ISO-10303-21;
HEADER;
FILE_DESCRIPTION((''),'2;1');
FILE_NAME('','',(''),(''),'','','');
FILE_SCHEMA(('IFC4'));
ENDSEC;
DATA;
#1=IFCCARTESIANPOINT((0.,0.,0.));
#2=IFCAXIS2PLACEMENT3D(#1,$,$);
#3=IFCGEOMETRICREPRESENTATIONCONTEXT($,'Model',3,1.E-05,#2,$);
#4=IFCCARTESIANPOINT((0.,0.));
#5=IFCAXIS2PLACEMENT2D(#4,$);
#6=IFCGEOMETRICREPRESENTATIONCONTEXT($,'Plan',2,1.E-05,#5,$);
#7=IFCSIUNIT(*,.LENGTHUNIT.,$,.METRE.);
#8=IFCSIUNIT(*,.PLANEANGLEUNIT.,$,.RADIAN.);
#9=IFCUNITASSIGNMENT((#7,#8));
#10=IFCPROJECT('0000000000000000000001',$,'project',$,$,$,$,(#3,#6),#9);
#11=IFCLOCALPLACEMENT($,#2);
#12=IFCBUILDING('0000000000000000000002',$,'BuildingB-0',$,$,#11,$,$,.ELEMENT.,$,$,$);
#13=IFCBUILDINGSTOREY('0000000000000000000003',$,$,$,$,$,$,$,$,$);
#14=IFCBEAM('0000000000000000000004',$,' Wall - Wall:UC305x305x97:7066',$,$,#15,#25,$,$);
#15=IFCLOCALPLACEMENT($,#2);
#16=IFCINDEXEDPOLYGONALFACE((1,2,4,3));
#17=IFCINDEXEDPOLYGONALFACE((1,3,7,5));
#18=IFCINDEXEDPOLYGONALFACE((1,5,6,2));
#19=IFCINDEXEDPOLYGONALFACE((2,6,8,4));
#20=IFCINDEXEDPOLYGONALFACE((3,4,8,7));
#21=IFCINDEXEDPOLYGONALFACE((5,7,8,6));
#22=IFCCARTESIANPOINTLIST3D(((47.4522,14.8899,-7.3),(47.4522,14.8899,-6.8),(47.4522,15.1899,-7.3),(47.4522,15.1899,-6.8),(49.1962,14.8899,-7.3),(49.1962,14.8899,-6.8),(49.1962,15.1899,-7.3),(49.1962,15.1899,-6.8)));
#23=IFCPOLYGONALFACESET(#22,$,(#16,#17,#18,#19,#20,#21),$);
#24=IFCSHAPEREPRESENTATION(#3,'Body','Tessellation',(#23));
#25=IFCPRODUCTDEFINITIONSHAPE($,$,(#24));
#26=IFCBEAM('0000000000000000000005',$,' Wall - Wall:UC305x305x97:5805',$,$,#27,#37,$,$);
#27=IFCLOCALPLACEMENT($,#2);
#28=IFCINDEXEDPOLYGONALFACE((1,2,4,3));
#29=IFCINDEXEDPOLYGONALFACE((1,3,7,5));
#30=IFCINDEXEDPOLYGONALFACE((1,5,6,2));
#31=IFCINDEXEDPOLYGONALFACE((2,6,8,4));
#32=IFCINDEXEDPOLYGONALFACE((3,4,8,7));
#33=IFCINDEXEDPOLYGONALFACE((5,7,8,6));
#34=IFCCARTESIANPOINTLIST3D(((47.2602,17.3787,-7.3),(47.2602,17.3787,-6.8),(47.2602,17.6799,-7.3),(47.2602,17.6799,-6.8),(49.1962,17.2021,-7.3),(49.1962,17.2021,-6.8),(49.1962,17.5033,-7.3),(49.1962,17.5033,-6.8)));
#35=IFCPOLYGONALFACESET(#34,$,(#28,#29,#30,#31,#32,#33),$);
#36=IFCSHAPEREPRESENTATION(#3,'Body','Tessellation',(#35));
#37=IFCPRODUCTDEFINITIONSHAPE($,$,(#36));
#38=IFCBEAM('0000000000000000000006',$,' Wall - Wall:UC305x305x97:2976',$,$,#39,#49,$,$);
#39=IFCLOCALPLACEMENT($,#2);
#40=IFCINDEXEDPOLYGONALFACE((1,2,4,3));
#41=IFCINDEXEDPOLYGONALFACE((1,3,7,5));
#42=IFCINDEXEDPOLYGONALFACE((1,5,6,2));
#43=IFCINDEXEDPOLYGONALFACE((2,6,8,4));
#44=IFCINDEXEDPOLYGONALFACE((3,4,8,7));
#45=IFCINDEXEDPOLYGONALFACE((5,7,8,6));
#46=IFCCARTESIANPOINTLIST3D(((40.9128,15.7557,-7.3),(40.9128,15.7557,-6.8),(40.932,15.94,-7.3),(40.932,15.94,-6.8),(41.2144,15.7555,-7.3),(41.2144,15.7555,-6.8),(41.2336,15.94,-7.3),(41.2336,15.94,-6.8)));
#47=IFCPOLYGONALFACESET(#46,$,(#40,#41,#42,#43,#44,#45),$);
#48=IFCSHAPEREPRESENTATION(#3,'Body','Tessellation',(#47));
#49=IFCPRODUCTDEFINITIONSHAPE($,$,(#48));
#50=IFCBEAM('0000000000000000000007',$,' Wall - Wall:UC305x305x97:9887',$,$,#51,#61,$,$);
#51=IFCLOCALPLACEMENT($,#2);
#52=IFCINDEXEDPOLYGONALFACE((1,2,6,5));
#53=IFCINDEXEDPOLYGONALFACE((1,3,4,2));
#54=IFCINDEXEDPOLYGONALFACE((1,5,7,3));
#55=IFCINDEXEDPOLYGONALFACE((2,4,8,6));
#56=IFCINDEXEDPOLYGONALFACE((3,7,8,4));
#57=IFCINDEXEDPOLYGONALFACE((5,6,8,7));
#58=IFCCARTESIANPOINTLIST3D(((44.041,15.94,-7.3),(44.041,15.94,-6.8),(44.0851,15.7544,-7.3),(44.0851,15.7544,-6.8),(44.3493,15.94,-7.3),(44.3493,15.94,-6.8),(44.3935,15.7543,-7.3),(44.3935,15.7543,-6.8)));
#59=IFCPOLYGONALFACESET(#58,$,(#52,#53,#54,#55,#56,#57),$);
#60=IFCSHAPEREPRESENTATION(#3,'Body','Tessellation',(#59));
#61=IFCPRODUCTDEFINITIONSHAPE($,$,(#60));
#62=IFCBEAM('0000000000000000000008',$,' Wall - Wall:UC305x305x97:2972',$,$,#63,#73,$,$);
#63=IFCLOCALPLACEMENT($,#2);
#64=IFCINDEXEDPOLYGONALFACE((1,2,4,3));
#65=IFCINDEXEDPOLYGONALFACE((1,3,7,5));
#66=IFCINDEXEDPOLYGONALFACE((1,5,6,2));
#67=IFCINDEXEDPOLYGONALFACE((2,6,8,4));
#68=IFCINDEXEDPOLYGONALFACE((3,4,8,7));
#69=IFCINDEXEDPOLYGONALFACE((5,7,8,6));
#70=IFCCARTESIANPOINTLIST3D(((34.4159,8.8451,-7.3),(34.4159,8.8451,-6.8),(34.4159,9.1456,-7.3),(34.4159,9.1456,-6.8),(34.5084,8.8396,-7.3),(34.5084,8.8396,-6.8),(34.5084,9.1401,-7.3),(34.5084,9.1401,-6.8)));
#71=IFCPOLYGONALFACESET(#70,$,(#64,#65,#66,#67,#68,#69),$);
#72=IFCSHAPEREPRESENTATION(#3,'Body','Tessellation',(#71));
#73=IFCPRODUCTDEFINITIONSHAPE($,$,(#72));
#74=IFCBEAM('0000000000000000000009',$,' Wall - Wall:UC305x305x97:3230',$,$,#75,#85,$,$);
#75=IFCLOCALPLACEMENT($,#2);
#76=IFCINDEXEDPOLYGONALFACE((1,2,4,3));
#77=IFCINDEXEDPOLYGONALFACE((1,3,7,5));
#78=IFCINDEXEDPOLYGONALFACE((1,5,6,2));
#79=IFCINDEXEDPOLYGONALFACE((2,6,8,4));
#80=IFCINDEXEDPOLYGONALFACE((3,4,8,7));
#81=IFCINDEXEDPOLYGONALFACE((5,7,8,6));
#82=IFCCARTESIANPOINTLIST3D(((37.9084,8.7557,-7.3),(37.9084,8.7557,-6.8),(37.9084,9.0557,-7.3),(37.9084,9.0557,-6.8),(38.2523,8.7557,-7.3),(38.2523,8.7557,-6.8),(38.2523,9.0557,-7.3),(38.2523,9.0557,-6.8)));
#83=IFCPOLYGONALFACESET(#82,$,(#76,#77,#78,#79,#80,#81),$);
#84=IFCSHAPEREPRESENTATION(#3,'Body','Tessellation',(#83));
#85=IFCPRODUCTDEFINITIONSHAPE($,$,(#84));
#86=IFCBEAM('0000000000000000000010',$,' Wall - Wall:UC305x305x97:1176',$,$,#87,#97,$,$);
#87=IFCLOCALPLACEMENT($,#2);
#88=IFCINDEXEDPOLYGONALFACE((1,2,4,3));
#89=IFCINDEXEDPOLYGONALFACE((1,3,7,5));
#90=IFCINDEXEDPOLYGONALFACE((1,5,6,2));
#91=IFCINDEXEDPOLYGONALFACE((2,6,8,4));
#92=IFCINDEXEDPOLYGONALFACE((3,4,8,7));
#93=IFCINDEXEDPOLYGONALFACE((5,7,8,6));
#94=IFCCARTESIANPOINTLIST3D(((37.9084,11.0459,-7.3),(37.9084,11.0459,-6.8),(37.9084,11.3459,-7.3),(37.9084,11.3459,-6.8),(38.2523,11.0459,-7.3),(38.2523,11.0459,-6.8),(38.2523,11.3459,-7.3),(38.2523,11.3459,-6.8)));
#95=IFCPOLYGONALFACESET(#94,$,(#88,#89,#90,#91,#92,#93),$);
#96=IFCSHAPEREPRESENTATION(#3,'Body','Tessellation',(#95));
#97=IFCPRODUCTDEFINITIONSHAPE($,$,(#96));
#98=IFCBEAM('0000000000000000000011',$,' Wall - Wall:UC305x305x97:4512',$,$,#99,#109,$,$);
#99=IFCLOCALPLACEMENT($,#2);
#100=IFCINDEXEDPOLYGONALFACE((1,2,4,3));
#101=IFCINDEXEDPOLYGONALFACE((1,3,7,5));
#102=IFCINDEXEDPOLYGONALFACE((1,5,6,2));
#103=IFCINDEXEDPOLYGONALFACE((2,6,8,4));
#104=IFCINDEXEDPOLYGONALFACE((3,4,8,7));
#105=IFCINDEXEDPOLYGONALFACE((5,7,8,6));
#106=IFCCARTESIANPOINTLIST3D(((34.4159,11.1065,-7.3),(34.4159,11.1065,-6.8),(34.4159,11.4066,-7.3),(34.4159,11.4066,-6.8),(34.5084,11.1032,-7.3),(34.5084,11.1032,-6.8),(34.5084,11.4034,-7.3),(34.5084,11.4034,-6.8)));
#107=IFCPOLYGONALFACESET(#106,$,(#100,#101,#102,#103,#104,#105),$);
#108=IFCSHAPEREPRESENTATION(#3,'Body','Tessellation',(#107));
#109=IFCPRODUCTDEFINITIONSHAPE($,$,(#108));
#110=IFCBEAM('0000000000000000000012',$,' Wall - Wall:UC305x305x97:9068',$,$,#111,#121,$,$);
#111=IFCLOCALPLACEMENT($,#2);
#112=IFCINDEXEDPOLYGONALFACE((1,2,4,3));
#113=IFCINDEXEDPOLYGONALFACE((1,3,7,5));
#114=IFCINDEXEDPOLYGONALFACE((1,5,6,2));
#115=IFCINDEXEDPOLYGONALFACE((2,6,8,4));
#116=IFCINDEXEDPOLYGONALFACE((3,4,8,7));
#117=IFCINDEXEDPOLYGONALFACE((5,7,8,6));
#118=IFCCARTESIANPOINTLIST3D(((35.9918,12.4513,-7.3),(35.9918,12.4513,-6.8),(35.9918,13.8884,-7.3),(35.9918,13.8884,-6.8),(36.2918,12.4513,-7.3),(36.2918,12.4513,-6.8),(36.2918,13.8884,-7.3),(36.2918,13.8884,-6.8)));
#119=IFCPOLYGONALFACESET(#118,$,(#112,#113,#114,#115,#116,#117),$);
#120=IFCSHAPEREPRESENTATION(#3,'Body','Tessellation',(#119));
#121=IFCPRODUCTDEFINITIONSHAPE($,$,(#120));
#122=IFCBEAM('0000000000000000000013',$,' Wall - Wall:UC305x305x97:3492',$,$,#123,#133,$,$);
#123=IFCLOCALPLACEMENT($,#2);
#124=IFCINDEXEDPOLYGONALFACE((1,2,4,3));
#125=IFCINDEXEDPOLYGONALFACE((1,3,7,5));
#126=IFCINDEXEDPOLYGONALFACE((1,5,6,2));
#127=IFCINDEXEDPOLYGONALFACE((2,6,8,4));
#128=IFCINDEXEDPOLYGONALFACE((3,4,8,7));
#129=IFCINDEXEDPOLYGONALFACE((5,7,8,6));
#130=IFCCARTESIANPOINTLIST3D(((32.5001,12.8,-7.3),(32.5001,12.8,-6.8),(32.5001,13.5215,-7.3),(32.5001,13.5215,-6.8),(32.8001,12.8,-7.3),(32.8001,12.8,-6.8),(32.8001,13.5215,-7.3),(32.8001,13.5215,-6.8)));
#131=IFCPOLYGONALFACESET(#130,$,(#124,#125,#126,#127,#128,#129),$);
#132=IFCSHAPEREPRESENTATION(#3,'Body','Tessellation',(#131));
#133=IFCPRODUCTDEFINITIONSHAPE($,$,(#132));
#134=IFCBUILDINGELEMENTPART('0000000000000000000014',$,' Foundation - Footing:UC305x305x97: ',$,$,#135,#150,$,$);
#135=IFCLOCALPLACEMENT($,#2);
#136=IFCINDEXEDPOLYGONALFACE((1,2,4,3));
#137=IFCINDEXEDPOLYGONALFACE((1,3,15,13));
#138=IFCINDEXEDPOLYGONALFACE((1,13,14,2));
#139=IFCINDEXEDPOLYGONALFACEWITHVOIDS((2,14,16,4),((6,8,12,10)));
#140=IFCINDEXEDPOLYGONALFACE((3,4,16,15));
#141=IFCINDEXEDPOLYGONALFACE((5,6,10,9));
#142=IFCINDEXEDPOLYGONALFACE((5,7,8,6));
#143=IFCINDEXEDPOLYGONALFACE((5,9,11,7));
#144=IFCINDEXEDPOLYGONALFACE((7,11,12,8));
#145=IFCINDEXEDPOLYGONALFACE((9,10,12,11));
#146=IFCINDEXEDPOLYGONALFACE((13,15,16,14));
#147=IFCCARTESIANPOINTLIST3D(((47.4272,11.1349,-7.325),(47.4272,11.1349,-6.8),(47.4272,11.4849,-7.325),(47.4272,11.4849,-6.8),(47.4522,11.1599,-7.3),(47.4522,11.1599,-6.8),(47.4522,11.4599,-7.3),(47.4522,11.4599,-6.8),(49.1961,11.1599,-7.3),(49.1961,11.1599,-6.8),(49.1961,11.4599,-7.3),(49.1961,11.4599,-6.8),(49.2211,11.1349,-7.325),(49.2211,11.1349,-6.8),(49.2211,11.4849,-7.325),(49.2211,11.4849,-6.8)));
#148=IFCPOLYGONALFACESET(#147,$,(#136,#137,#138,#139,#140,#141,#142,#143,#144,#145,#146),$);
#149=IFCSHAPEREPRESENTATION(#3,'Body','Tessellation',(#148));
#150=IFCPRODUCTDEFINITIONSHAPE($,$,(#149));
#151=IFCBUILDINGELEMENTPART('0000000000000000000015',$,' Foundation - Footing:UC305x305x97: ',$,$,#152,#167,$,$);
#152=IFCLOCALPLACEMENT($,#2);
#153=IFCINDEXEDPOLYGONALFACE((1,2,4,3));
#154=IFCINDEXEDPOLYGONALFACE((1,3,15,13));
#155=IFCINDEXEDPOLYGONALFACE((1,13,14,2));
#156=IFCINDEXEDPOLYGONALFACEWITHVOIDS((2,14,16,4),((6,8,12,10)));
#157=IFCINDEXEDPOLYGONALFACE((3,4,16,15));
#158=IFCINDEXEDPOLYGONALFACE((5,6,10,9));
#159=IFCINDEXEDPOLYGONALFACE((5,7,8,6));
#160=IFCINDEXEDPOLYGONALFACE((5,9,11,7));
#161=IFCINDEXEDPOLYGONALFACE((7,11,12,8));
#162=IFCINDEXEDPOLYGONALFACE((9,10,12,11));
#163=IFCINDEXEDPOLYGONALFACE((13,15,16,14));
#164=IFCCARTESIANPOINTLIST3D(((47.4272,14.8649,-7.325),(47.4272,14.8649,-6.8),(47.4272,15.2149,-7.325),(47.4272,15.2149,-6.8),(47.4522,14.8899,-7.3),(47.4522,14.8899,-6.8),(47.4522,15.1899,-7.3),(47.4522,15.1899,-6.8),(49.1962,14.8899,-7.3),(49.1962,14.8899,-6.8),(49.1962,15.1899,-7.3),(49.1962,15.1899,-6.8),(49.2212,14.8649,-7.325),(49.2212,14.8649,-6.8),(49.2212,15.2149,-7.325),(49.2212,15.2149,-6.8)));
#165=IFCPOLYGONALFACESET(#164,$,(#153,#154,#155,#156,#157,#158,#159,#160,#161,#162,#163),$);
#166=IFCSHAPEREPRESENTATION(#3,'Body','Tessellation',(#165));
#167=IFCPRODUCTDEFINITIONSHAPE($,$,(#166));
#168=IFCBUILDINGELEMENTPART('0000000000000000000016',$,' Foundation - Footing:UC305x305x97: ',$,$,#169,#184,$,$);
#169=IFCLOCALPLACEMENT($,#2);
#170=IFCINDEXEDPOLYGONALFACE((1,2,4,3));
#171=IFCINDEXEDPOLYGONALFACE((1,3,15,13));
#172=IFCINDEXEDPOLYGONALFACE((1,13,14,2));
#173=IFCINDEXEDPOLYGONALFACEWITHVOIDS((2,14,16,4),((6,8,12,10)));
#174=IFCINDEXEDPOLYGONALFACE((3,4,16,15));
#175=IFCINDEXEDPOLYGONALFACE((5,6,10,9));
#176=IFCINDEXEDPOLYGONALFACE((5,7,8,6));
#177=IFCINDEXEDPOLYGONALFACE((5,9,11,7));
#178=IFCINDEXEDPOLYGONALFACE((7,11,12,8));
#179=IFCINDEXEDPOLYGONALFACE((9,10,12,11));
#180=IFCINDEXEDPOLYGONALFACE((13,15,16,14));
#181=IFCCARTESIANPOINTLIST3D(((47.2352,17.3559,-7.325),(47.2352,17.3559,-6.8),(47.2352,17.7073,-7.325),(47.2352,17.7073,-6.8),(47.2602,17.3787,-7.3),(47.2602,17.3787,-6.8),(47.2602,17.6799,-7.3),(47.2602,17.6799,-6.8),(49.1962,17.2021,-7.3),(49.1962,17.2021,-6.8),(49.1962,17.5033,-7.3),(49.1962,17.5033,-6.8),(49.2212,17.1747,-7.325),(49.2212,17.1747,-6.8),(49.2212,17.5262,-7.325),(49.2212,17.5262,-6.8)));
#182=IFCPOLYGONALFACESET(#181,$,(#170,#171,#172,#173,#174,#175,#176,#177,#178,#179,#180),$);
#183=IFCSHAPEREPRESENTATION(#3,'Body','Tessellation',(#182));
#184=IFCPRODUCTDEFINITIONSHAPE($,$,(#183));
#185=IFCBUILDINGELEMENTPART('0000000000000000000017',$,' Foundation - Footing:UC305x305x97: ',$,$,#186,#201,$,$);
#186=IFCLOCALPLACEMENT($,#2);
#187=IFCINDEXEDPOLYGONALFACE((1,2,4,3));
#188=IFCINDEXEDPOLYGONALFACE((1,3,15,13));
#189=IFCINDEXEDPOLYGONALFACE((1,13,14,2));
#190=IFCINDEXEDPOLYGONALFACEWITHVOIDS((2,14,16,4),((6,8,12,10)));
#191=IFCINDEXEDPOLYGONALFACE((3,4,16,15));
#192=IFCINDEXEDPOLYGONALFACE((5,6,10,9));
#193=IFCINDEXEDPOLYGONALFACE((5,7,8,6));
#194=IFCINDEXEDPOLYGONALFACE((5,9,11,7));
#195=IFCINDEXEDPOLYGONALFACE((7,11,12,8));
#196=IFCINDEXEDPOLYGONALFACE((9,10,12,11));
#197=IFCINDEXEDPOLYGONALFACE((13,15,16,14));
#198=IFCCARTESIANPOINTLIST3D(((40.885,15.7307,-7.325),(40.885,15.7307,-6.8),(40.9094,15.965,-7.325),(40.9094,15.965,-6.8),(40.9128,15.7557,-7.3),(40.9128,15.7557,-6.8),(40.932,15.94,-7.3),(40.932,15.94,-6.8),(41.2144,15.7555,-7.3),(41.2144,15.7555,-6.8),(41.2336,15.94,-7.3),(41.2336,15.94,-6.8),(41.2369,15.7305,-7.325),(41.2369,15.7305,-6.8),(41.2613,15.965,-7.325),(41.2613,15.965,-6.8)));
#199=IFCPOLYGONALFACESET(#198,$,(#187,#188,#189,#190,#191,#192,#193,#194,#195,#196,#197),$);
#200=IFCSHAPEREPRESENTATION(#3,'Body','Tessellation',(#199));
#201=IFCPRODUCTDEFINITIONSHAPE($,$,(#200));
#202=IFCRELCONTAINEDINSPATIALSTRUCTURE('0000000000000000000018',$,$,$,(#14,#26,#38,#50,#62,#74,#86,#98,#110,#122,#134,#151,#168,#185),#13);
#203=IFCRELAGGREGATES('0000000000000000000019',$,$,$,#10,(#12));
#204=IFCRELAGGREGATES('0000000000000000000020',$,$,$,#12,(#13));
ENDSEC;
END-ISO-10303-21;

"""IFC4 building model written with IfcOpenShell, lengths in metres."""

from ifc_helpers import new_model, si_unit, origin, origin_2d, place, context, project, spatial, polyline, outline, extrude, element, save


model = new_model("IFC4")

# Units and contexts
model_context = context("Model", 3, precision=1e-05, world=origin())
plan_context = context("Plan", 2, precision=1e-05, world=origin_2d())
ifc_project = project(units=[si_unit("LENGTHUNIT", "METRE"), si_unit("PLANEANGLEUNIT", "RADIAN")], contexts=[model_context, plan_context])

# Building, storey
building_placement = place(None, origin())
building = spatial("IfcBuilding", under=ifc_project, at=building_placement, Name="BuildingB-0", CompositionType="ELEMENT")
storey = spatial("IfcBuildingStorey", under=building)

# Beams
element("IfcBeam", 1, inside=storey, Name=" Wall - Wall:UC305x305x97:7066", context=model_context, shape_type="SweptSolid", body=[
    extrude(outline(polyline([(47.4522, 14.8899, -7.3), (47.4522, 15.1899, -7.3), (49.1962, 15.1899, -7.3), (49.1962, 14.8899, -7.3), (47.4522, 14.8899, -7.3)])), None, (0.0, 0.0, 1.0), 0.5),
])
element("IfcBeam", 2, inside=storey, Name=" Wall - Wall:UC305x305x97:5805", context=model_context, shape_type="SweptSolid", body=[
    extrude(outline(polyline([(47.2602, 17.3787, -7.3), (47.2602, 17.6799, -7.3), (49.1962, 17.5033, -7.3), (49.1962, 17.2021, -7.3), (47.2602, 17.3787, -7.3)])), None, (0.0, 0.0, 1.0), 0.5),
])
element("IfcBeam", 3, inside=storey, Name=" Wall - Wall:UC305x305x97:2976", context=model_context, shape_type="SweptSolid", body=[
    extrude(outline(polyline([(40.9128, 15.7557, -7.3), (40.932, 15.94, -7.3), (41.2336, 15.94, -7.3), (41.2144, 15.7555, -7.3), (40.9128, 15.7557, -7.3)])), None, (0.0, 0.0, 1.0), 0.5),
])
element("IfcBeam", 4, inside=storey, Name=" Wall - Wall:UC305x305x97:9887", context=model_context, shape_type="SweptSolid", body=[
    extrude(outline(polyline([(44.0851, 15.7544, -7.3), (44.041, 15.94, -7.3), (44.3493, 15.94, -7.3), (44.3935, 15.7543, -7.3), (44.0851, 15.7544, -7.3)])), None, (0.0, 0.0, 1.0), 0.5),
])
element("IfcBeam", 5, inside=storey, Name=" Wall - Wall:UC305x305x97:2972", context=model_context, shape_type="SweptSolid", body=[
    extrude(outline(polyline([(34.4159, 8.8451, -7.3), (34.5084, 8.8396, -7.3), (34.5084, 9.1401, -7.3), (34.4159, 9.1456, -7.3), (34.4159, 8.8451, -7.3)])), None, (0.0, 0.0, 1.0), 0.5),
])
element("IfcBeam", 6, inside=storey, Name=" Wall - Wall:UC305x305x97:3230", context=model_context, shape_type="SweptSolid", body=[
    extrude(outline(polyline([(37.9084, 8.7557, -7.3), (38.2523, 8.7557, -7.3), (38.2523, 9.0557, -7.3), (37.9084, 9.0557, -7.3), (37.9084, 8.7557, -7.3)])), None, (0.0, 0.0, 1.0), 0.5),
])
element("IfcBeam", 7, inside=storey, Name=" Wall - Wall:UC305x305x97:1176", context=model_context, shape_type="SweptSolid", body=[
    extrude(outline(polyline([(37.9084, 11.0459, -7.3), (38.2523, 11.0459, -7.3), (38.2523, 11.3459, -7.3), (37.9084, 11.3459, -7.3), (37.9084, 11.0459, -7.3)])), None, (0.0, 0.0, 1.0), 0.5),
])
element("IfcBeam", 8, inside=storey, Name=" Wall - Wall:UC305x305x97:4512", context=model_context, shape_type="SweptSolid", body=[
    extrude(outline(polyline([(34.4159, 11.1065, -7.3), (34.5084, 11.1032, -7.3), (34.5084, 11.4034, -7.3), (34.4159, 11.4066, -7.3), (34.4159, 11.1065, -7.3)])), None, (0.0, 0.0, 1.0), 0.5),
])
element("IfcBeam", 9, inside=storey, Name=" Wall - Wall:UC305x305x97:9068", context=model_context, shape_type="SweptSolid", body=[
    extrude(outline(polyline([(35.9918, 12.4513, -7.3), (36.2918, 12.4513, -7.3), (36.2918, 13.8884, -7.3), (35.9918, 13.8884, -7.3), (35.9918, 12.4513, -7.3)])), None, (0.0, 0.0, 1.0), 0.5),
])
element("IfcBeam", 10, inside=storey, Name=" Wall - Wall:UC305x305x97:3492", context=model_context, shape_type="SweptSolid", body=[
    extrude(outline(polyline([(32.5001, 12.8, -7.3), (32.8001, 12.8, -7.3), (32.8001, 13.5215, -7.3), (32.5001, 13.5215, -7.3), (32.5001, 12.8, -7.3)])), None, (0.0, 0.0, 1.0), 0.5),
])

# Building element parts, openings
building_element_part_1 = element("IfcBuildingElementPart", 11, inside=storey, Name=" Foundation - Footing:UC305x305x97: ", context=model_context, shape_type="SweptSolid", body=[
    extrude(outline(polyline([(47.4272, 11.1349, -7.325), (47.4272, 11.4849, -7.325), (49.2211, 11.4849, -7.325), (49.2211, 11.1349, -7.325), (47.4272, 11.1349, -7.325)])), None, (0.0, 0.0, 1.0), 0.525),
])
element("IfcOpeningElement", 12, inside=storey, cuts=building_element_part_1, context=model_context, shape_type="SweptSolid", body=[
    extrude(outline(polyline([(47.4522, 11.1599, -7.3), (47.4522, 11.4599, -7.3), (49.1961, 11.4599, -7.3), (49.1961, 11.1599, -7.3), (47.4522, 11.1599, -7.3)])), None, (0.0, 0.0, 1.0), 0.5),
])
building_element_part_2 = element("IfcBuildingElementPart", 13, inside=storey, Name=" Foundation - Footing:UC305x305x97: ", context=model_context, shape_type="SweptSolid", body=[
    extrude(outline(polyline([(47.4272, 14.8649, -7.325), (47.4272, 15.2149, -7.325), (49.2212, 15.2149, -7.325), (49.2212, 14.8649, -7.325), (47.4272, 14.8649, -7.325)])), None, (0.0, 0.0, 1.0), 0.525),
])
element("IfcOpeningElement", 14, inside=storey, cuts=building_element_part_2, context=model_context, shape_type="SweptSolid", body=[
    extrude(outline(polyline([(47.4522, 14.8899, -7.3), (47.4522, 15.1899, -7.3), (49.1962, 15.1899, -7.3), (49.1962, 14.8899, -7.3), (47.4522, 14.8899, -7.3)])), None, (0.0, 0.0, 1.0), 0.5),
])
building_element_part_3 = element("IfcBuildingElementPart", 15, inside=storey, Name=" Foundation - Footing:UC305x305x97: ", context=model_context, shape_type="SweptSolid", body=[
    extrude(outline(polyline([(47.2352, 17.3559, -7.325), (47.2352, 17.7073, -7.325), (49.2212, 17.5262, -7.325), (49.2212, 17.1747, -7.325), (47.2352, 17.3559, -7.325)])), None, (0.0, 0.0, 1.0), 0.525),
])
element("IfcOpeningElement", 16, inside=storey, cuts=building_element_part_3, context=model_context, shape_type="SweptSolid", body=[
    extrude(outline(polyline([(47.2602, 17.3787, -7.3), (47.2602, 17.6799, -7.3), (49.1962, 17.5033, -7.3), (49.1962, 17.2021, -7.3), (47.2602, 17.3787, -7.3)])), None, (0.0, 0.0, 1.0), 0.5),
])
building_element_part_4 = element("IfcBuildingElementPart", 17, inside=storey, Name=" Foundation - Footing:UC305x305x97: ", context=model_context, shape_type="SweptSolid", body=[
    extrude(outline(polyline([(40.885, 15.7307, -7.325), (40.9094, 15.965, -7.325), (41.2613, 15.965, -7.325), (41.2369, 15.7305, -7.325), (40.885, 15.7307, -7.325)])), None, (0.0, 0.0, 1.0), 0.525),
])
element("IfcOpeningElement", 18, inside=storey, cuts=building_element_part_4, context=model_context, shape_type="SweptSolid", body=[
    extrude(outline(polyline([(40.9128, 15.7557, -7.3), (40.932, 15.94, -7.3), (41.2336, 15.94, -7.3), (41.2144, 15.7555, -7.3), (40.9128, 15.7557, -7.3)])), None, (0.0, 0.0, 1.0), 0.5),
])

save(model, "model.ifc")
